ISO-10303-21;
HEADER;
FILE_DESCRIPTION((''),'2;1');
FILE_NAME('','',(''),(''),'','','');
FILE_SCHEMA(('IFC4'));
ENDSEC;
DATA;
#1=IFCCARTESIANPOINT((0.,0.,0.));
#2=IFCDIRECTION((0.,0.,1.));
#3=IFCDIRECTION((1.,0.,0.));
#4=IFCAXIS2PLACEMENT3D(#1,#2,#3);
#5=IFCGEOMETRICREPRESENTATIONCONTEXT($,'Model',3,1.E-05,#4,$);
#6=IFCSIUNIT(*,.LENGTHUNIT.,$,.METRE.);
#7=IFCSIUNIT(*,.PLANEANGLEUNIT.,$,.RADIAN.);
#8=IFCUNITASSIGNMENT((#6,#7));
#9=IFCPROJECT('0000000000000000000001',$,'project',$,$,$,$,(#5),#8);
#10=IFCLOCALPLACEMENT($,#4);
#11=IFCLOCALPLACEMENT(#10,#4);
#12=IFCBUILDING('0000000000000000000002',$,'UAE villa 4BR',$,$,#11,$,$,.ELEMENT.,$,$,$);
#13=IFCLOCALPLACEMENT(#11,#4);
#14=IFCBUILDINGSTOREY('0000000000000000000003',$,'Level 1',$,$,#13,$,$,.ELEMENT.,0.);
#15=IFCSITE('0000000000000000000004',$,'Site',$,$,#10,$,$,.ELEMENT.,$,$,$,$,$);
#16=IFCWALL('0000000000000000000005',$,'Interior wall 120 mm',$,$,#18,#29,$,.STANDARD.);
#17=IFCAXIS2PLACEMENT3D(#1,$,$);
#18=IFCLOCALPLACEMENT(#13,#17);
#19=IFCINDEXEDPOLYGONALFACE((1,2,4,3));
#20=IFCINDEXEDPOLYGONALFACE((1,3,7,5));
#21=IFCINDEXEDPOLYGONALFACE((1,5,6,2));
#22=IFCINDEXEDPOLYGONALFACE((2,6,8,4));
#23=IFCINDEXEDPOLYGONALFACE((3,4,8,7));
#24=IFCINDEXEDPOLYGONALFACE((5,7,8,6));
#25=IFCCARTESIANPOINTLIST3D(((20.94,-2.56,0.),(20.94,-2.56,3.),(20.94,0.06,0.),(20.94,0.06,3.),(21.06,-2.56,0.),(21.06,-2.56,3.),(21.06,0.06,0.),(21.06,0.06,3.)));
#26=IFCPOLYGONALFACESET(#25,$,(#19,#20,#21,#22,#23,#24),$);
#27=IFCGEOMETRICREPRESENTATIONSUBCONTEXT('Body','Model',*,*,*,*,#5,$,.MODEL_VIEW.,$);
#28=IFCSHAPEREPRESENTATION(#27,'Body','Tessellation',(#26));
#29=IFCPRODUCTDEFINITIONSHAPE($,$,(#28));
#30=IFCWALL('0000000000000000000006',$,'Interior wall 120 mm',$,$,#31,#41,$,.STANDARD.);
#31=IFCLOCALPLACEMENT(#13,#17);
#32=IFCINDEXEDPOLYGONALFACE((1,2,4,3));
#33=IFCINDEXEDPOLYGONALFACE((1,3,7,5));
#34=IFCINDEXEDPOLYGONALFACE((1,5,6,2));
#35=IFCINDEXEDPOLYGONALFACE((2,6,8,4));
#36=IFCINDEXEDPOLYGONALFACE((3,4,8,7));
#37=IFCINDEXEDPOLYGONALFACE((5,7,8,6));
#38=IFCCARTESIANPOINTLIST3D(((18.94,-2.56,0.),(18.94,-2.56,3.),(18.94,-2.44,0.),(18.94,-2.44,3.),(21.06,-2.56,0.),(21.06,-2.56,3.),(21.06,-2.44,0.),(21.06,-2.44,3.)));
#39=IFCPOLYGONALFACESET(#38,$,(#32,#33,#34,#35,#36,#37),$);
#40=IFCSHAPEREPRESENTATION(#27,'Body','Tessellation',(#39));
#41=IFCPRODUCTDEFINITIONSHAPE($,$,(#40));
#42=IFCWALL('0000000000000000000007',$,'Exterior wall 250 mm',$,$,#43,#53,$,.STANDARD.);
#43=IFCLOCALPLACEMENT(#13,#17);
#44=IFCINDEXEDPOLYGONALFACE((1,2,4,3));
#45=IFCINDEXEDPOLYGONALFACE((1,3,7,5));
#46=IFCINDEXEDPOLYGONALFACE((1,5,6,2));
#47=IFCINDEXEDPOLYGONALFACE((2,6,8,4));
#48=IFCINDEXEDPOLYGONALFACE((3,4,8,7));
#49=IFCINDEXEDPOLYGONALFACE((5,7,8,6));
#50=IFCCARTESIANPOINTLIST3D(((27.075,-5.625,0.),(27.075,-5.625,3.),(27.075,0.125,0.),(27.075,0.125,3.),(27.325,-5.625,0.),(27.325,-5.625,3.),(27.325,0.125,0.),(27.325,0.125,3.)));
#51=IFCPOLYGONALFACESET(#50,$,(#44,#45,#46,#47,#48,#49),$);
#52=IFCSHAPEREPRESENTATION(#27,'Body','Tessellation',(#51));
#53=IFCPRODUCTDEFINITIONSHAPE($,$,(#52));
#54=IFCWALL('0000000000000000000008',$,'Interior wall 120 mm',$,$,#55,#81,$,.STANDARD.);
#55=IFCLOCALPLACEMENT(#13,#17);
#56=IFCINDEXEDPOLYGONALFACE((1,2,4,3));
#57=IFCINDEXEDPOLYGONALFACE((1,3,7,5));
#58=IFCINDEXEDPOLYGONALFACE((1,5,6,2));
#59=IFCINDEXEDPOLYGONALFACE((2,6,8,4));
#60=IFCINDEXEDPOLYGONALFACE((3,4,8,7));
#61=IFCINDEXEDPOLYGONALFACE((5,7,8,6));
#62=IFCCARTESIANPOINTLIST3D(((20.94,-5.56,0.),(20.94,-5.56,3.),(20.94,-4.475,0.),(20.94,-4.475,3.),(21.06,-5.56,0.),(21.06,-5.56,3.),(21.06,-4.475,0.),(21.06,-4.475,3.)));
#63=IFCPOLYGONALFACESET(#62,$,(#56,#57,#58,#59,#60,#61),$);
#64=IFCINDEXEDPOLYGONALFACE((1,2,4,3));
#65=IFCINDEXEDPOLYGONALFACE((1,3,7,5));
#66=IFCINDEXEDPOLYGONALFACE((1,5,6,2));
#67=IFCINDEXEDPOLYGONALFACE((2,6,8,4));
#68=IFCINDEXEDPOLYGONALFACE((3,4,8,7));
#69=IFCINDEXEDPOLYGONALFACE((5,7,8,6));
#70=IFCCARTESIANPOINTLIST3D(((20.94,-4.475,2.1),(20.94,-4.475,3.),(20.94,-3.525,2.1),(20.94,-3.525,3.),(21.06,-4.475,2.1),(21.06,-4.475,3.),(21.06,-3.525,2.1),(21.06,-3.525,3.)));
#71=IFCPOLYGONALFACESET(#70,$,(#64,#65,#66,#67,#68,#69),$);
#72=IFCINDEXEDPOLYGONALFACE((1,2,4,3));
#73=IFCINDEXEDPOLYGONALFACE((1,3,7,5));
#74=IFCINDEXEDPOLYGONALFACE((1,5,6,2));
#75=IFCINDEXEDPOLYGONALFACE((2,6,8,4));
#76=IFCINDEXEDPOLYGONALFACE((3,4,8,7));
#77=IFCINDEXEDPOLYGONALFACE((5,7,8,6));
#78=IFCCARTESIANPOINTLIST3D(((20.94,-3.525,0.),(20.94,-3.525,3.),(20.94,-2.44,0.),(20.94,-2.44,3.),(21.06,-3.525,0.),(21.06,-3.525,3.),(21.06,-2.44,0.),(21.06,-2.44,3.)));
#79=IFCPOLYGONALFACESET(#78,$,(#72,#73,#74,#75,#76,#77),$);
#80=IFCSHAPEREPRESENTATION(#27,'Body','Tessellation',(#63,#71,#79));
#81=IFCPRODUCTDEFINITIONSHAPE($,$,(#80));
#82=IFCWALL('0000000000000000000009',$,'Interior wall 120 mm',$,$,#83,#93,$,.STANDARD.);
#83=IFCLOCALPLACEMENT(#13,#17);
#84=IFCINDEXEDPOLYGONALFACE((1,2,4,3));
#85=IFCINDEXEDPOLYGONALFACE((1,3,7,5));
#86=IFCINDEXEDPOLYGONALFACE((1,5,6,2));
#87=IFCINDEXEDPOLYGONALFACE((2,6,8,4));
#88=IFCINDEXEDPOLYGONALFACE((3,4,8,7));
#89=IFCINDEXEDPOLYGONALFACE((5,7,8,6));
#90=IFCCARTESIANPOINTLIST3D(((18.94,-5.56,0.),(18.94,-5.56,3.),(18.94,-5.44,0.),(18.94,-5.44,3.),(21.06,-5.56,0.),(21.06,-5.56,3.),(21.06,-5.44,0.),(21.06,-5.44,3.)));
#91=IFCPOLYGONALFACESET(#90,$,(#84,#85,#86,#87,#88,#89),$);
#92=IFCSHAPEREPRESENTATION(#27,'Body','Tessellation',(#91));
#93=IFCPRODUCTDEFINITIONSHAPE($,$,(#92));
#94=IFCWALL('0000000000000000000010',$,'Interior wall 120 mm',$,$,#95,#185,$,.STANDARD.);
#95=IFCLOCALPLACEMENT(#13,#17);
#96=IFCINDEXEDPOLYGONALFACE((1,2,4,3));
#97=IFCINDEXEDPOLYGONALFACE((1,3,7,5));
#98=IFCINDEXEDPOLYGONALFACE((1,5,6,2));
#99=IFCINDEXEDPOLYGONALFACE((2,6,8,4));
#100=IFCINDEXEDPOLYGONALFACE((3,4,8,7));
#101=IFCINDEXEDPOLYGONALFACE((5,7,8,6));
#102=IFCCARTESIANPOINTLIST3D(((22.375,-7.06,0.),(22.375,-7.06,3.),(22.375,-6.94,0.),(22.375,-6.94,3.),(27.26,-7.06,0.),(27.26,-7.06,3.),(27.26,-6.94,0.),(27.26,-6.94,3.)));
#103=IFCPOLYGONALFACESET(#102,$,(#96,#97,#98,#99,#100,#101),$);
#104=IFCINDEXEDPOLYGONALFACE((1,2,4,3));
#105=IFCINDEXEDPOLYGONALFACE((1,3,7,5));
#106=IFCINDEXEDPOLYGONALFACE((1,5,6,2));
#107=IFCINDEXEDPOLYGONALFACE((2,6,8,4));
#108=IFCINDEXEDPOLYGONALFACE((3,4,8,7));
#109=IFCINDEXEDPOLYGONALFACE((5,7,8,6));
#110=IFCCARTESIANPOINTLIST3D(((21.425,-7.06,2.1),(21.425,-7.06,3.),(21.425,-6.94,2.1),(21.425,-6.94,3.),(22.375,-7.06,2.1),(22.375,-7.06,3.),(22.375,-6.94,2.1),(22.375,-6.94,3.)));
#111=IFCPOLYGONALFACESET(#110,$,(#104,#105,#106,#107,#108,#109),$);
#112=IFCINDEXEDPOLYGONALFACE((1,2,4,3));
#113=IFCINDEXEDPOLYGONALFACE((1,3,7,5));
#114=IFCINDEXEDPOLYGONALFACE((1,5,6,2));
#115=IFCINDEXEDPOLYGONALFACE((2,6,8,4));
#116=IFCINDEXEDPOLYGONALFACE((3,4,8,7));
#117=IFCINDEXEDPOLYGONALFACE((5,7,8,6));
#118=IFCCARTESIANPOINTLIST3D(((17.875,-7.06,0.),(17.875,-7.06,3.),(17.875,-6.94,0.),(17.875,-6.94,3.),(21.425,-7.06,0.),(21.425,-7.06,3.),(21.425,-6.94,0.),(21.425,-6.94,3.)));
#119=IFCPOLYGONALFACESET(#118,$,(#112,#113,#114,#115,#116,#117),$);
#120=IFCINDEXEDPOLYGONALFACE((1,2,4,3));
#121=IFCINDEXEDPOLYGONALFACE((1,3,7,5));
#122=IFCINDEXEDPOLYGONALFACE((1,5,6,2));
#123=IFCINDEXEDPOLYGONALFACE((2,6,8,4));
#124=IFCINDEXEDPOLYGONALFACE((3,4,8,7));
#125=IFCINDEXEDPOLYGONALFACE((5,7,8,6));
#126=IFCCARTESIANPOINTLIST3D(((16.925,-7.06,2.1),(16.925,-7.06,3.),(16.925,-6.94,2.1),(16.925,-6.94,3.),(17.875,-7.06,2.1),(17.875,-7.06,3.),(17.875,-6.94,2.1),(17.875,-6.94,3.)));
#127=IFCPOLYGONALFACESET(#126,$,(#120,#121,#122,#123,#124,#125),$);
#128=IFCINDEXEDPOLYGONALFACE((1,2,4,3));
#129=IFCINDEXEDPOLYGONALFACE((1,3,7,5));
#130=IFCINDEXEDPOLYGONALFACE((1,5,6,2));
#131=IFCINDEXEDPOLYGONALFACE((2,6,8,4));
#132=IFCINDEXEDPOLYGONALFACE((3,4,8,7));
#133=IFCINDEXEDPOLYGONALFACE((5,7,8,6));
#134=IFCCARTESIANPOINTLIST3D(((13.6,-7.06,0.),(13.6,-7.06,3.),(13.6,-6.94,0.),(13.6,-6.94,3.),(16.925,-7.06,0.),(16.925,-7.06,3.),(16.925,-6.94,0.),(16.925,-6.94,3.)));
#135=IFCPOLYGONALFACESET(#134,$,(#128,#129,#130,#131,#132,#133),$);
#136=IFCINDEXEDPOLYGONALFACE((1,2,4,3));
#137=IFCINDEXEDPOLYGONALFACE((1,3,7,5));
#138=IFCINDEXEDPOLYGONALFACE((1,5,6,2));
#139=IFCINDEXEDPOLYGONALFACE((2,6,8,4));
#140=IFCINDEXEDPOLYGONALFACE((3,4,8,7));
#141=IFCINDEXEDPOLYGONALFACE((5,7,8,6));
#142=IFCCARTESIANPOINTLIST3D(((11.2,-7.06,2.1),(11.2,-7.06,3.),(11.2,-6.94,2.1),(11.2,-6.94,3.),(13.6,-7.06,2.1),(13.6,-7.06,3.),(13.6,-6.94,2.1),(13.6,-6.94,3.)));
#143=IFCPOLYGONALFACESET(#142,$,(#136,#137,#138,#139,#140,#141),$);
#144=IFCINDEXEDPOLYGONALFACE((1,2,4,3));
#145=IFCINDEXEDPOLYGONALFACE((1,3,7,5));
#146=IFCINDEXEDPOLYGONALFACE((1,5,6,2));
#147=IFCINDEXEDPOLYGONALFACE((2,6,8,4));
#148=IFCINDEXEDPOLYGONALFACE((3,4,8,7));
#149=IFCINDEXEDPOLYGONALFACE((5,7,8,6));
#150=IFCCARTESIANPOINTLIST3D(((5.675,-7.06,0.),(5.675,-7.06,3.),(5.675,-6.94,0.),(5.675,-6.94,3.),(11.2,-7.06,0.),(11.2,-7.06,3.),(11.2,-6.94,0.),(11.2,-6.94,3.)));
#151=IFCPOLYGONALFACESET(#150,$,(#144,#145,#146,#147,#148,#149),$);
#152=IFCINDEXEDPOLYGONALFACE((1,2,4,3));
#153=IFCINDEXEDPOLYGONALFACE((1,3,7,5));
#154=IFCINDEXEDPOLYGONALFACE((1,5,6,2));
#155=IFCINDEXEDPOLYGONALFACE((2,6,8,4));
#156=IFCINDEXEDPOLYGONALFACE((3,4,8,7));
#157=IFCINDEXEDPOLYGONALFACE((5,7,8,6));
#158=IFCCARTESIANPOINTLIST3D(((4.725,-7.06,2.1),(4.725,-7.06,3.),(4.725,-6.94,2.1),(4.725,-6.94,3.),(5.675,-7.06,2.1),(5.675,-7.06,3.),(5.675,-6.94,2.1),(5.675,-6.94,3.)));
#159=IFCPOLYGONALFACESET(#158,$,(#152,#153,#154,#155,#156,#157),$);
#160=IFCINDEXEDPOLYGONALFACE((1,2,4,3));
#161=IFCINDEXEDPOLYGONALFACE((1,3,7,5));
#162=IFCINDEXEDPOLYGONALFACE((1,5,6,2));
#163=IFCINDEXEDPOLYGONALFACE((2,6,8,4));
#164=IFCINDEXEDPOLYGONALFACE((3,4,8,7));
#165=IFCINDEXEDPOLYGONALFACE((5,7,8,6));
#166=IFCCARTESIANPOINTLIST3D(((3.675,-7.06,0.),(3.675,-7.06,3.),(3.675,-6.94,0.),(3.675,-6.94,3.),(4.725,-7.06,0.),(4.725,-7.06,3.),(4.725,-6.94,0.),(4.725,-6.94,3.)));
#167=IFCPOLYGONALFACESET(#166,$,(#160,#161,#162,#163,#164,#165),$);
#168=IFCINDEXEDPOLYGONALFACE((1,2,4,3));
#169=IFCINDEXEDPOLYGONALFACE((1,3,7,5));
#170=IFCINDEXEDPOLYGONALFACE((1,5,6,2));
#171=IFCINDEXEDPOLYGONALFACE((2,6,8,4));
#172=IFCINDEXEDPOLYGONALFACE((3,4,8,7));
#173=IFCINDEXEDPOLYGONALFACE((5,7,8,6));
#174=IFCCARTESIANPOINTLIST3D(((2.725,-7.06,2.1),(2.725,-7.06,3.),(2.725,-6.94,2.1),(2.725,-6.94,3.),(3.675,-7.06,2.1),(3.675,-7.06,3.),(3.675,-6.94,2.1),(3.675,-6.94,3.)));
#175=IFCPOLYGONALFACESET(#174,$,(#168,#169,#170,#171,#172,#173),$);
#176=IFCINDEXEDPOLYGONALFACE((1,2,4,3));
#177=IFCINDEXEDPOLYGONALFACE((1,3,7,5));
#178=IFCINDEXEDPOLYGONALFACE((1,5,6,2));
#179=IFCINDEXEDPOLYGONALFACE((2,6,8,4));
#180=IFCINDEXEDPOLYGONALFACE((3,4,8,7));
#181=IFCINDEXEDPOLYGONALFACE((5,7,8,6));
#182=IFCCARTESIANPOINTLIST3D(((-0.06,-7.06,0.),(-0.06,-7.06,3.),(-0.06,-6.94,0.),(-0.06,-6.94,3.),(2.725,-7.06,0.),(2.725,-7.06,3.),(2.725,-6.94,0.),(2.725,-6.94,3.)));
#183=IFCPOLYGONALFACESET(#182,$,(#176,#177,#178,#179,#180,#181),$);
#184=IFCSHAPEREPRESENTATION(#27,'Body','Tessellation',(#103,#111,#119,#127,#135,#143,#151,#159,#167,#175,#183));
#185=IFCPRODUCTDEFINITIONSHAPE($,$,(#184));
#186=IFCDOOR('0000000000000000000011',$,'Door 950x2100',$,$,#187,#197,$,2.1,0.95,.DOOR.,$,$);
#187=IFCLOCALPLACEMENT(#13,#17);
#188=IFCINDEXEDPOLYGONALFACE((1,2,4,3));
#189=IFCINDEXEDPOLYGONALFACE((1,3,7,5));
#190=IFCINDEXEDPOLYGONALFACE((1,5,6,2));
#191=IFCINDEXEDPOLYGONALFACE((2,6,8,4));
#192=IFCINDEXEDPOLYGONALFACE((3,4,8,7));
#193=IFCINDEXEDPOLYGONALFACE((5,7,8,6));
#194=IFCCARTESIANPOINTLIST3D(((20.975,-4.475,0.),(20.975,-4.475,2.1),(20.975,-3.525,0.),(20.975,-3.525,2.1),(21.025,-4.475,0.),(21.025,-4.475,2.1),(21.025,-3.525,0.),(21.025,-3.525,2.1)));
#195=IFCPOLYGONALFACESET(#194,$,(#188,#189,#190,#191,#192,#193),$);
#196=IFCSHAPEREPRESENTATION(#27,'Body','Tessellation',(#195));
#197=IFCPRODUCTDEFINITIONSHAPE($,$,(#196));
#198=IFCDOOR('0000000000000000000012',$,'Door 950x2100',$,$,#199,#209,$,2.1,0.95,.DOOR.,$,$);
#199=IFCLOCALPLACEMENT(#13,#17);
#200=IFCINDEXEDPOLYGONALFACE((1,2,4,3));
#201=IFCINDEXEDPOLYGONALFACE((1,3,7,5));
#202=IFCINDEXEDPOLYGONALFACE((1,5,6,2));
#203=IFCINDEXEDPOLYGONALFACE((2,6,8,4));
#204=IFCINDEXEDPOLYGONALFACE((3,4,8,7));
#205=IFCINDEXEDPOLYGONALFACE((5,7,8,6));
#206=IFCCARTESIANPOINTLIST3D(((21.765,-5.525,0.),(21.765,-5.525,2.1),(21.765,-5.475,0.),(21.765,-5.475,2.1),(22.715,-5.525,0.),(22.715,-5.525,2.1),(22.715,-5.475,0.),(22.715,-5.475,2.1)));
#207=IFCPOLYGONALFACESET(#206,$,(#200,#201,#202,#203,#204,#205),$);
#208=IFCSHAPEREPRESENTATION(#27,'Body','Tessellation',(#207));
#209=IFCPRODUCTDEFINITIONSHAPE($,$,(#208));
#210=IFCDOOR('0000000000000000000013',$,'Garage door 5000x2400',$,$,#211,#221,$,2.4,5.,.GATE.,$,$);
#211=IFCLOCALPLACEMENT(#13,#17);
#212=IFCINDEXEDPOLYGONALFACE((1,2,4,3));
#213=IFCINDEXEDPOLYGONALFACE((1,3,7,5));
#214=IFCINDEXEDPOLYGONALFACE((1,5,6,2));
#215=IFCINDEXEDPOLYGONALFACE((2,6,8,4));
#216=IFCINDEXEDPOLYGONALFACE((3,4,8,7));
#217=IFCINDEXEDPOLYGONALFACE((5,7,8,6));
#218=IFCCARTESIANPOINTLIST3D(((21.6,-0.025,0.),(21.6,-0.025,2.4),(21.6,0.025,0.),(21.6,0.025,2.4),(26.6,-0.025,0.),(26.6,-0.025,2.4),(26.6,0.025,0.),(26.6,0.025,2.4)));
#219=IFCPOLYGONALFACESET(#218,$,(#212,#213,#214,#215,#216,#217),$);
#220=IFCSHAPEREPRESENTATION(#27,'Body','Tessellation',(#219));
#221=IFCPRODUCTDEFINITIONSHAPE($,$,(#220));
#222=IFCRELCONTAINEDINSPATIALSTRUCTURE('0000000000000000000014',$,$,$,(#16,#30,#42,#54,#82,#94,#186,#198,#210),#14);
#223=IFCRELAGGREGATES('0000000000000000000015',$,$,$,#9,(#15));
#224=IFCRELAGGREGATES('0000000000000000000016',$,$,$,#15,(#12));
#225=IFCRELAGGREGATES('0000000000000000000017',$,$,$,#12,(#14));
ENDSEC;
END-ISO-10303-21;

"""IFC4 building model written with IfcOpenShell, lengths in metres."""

from ifc_helpers import new_model, si_unit, frame, origin, origin_with_axes, origin_2d, place, context, subcontext, project, spatial, rectangle, extrude, element, save


model = new_model("IFC4")

# Units and contexts
model_context = context("Model", 3, precision=1e-05, world=origin_with_axes())
body_context = subcontext(model_context, "Body", "Model", "MODEL_VIEW")
ifc_project = project(units=[si_unit("LENGTHUNIT", "METRE"), si_unit("PLANEANGLEUNIT", "RADIAN")], contexts=[model_context])

# Site, building, storey
site_placement = place(None, origin_with_axes())
site = spatial("IfcSite", under=ifc_project, at=site_placement, Name="Site", CompositionType="ELEMENT")
building_placement = place(site_placement, origin_with_axes())
building = spatial("IfcBuilding", under=site, at=building_placement, Name="UAE villa 4BR", CompositionType="ELEMENT")
storey_placement = place(building_placement, origin_with_axes())
storey = spatial("IfcBuildingStorey", under=building, at=storey_placement, Name="Level 1", CompositionType="ELEMENT", Elevation=0.0)

# Walls
wall_1_placement = place(storey_placement, frame((21.0, 0.0, 0.0), z_axis=(0.0, 0.0, 1.0), x_axis=(0.0, -1.0, 0.0)))
element("IfcWall", 1, at=wall_1_placement, inside=storey, Name="Interior wall 120 mm", PredefinedType="STANDARD", context=body_context, shape_type="SweptSolid", body=[
    extrude(rectangle(XDim=2.62, YDim=0.12, at=origin_2d()), frame((1.25, 0.0, 0.0)), (0.0, 0.0, 1.0), 3.0),
])
wall_2_placement = place(storey_placement, frame((21.0, -2.5, 0.0), z_axis=(0.0, 0.0, 1.0), x_axis=(-1.0, 0.0, 0.0)))
element("IfcWall", 2, at=wall_2_placement, inside=storey, Name="Interior wall 120 mm", PredefinedType="STANDARD", context=body_context, shape_type="SweptSolid", body=[
    extrude(rectangle(XDim=2.12, YDim=0.12, at=origin_2d()), frame((1.0, 0.0, 0.0)), (0.0, 0.0, 1.0), 3.0),
])
wall_3_placement = place(storey_placement, frame((27.2, 0.0, 0.0), z_axis=(0.0, 0.0, 1.0), x_axis=(0.0, -1.0, 0.0)))
element("IfcWall", 3, at=wall_3_placement, inside=storey, Name="Exterior wall 250 mm", PredefinedType="STANDARD", context=body_context, shape_type="SweptSolid", body=[
    extrude(rectangle(XDim=5.75, YDim=0.25, at=origin_2d()), frame((2.75, 0.0, 0.0)), (0.0, 0.0, 1.0), 3.0),
])
wall_4_placement = place(storey_placement, frame((21.0, -5.5, 0.0), z_axis=(0.0, 0.0, 1.0), x_axis=(0.0, 1.0, 0.0)))
element("IfcWall", 4, at=wall_4_placement, inside=storey, Name="Interior wall 120 mm", PredefinedType="STANDARD", context=body_context, shape_type="SweptSolid", body=[
    extrude(rectangle(XDim=1.085, YDim=0.12, at=origin_2d()), frame((0.4825, 0.0, 0.0)), (0.0, 0.0, 1.0), 3.0),
    extrude(rectangle(XDim=0.95, YDim=0.12, at=origin_2d()), frame((1.5, 0.0, 2.1)), (0.0, 0.0, 1.0), 0.9),
    extrude(rectangle(XDim=1.085, YDim=0.12, at=origin_2d()), frame((2.5175, 0.0, 0.0)), (0.0, 0.0, 1.0), 3.0),
])
wall_5_placement = place(storey_placement, frame((21.0, -5.5, 0.0), z_axis=(0.0, 0.0, 1.0), x_axis=(-1.0, 0.0, 0.0)))
element("IfcWall", 5, at=wall_5_placement, inside=storey, Name="Interior wall 120 mm", PredefinedType="STANDARD", context=body_context, shape_type="SweptSolid", body=[
    extrude(rectangle(XDim=2.12, YDim=0.12, at=origin_2d()), frame((1.0, 0.0, 0.0)), (0.0, 0.0, 1.0), 3.0),
])
wall_6_placement = place(storey_placement, frame((27.2, -7.0, 0.0), z_axis=(0.0, 0.0, 1.0), x_axis=(-1.0, 0.0, 0.0)))
element("IfcWall", 6, at=wall_6_placement, inside=storey, Name="Interior wall 120 mm", PredefinedType="STANDARD", context=body_context, shape_type="SweptSolid", body=[
    extrude(rectangle(XDim=4.885, YDim=0.12, at=origin_2d()), frame((2.3825, 0.0, 0.0)), (0.0, 0.0, 1.0), 3.0),
    extrude(rectangle(XDim=0.95, YDim=0.12, at=origin_2d()), frame((5.3, 0.0, 2.1)), (0.0, 0.0, 1.0), 0.9),
    extrude(rectangle(XDim=3.55, YDim=0.12, at=origin_2d()), frame((7.55, 0.0, 0.0)), (0.0, 0.0, 1.0), 3.0),
    extrude(rectangle(XDim=0.95, YDim=0.12, at=origin_2d()), frame((9.8, 0.0, 2.1)), (0.0, 0.0, 1.0), 0.9),
    extrude(rectangle(XDim=3.325, YDim=0.12, at=origin_2d()), frame((11.9375, 0.0, 0.0)), (0.0, 0.0, 1.0), 3.0),
    extrude(rectangle(XDim=2.4, YDim=0.12, at=origin_2d()), frame((14.8, 0.0, 2.1)), (0.0, 0.0, 1.0), 0.9),
    extrude(rectangle(XDim=5.525, YDim=0.12, at=origin_2d()), frame((18.7625, 0.0, 0.0)), (0.0, 0.0, 1.0), 3.0),
    extrude(rectangle(XDim=0.95, YDim=0.12, at=origin_2d()), frame((22.0, 0.0, 2.1)), (0.0, 0.0, 1.0), 0.9),
    extrude(rectangle(XDim=1.05, YDim=0.12, at=origin_2d()), frame((23.0, 0.0, 0.0)), (0.0, 0.0, 1.0), 3.0),
    extrude(rectangle(XDim=0.95, YDim=0.12, at=origin_2d()), frame((24.0, 0.0, 2.1)), (0.0, 0.0, 1.0), 0.9),
    extrude(rectangle(XDim=2.785, YDim=0.12, at=origin_2d()), frame((25.8675, 0.0, 0.0)), (0.0, 0.0, 1.0), 3.0),
])

# Doors
for number, where, z_axis, x_axis, name in (
    (7, (21.0, -4.0, 0.0), (0.0, 0.0, 1.0), (0.0, 1.0, 0.0), "Door 950x2100"),
    (8, (22.24, -5.5, 0.0), (0.0, 0.0, 1.0), (-1.0, 0.0, 0.0), "Door 950x2100"),
):
    element("IfcDoor", number, at=place(storey_placement, frame(where, z_axis=z_axis, x_axis=x_axis)), inside=storey, Name=name, OverallHeight=2.1, OverallWidth=0.95, PredefinedType="DOOR", context=body_context, shape_type="SweptSolid", body=[
        extrude(rectangle(XDim=0.95, YDim=0.05, at=origin_2d()), origin(), (0.0, 0.0, 1.0), 2.1),
    ])
door_1_placement = place(storey_placement, frame((24.1, 0.0, 0.0), z_axis=(0.0, 0.0, 1.0), x_axis=(1.0, 0.0, 0.0)))
element("IfcDoor", 9, at=door_1_placement, inside=storey, Name="Garage door 5000x2400", OverallHeight=2.4, OverallWidth=5.0, PredefinedType="GATE", context=body_context, shape_type="SweptSolid", body=[
    extrude(rectangle(XDim=5.0, YDim=0.05, at=origin_2d()), origin(), (0.0, 0.0, 1.0), 2.4),
])

save(model, "model.ifc")
